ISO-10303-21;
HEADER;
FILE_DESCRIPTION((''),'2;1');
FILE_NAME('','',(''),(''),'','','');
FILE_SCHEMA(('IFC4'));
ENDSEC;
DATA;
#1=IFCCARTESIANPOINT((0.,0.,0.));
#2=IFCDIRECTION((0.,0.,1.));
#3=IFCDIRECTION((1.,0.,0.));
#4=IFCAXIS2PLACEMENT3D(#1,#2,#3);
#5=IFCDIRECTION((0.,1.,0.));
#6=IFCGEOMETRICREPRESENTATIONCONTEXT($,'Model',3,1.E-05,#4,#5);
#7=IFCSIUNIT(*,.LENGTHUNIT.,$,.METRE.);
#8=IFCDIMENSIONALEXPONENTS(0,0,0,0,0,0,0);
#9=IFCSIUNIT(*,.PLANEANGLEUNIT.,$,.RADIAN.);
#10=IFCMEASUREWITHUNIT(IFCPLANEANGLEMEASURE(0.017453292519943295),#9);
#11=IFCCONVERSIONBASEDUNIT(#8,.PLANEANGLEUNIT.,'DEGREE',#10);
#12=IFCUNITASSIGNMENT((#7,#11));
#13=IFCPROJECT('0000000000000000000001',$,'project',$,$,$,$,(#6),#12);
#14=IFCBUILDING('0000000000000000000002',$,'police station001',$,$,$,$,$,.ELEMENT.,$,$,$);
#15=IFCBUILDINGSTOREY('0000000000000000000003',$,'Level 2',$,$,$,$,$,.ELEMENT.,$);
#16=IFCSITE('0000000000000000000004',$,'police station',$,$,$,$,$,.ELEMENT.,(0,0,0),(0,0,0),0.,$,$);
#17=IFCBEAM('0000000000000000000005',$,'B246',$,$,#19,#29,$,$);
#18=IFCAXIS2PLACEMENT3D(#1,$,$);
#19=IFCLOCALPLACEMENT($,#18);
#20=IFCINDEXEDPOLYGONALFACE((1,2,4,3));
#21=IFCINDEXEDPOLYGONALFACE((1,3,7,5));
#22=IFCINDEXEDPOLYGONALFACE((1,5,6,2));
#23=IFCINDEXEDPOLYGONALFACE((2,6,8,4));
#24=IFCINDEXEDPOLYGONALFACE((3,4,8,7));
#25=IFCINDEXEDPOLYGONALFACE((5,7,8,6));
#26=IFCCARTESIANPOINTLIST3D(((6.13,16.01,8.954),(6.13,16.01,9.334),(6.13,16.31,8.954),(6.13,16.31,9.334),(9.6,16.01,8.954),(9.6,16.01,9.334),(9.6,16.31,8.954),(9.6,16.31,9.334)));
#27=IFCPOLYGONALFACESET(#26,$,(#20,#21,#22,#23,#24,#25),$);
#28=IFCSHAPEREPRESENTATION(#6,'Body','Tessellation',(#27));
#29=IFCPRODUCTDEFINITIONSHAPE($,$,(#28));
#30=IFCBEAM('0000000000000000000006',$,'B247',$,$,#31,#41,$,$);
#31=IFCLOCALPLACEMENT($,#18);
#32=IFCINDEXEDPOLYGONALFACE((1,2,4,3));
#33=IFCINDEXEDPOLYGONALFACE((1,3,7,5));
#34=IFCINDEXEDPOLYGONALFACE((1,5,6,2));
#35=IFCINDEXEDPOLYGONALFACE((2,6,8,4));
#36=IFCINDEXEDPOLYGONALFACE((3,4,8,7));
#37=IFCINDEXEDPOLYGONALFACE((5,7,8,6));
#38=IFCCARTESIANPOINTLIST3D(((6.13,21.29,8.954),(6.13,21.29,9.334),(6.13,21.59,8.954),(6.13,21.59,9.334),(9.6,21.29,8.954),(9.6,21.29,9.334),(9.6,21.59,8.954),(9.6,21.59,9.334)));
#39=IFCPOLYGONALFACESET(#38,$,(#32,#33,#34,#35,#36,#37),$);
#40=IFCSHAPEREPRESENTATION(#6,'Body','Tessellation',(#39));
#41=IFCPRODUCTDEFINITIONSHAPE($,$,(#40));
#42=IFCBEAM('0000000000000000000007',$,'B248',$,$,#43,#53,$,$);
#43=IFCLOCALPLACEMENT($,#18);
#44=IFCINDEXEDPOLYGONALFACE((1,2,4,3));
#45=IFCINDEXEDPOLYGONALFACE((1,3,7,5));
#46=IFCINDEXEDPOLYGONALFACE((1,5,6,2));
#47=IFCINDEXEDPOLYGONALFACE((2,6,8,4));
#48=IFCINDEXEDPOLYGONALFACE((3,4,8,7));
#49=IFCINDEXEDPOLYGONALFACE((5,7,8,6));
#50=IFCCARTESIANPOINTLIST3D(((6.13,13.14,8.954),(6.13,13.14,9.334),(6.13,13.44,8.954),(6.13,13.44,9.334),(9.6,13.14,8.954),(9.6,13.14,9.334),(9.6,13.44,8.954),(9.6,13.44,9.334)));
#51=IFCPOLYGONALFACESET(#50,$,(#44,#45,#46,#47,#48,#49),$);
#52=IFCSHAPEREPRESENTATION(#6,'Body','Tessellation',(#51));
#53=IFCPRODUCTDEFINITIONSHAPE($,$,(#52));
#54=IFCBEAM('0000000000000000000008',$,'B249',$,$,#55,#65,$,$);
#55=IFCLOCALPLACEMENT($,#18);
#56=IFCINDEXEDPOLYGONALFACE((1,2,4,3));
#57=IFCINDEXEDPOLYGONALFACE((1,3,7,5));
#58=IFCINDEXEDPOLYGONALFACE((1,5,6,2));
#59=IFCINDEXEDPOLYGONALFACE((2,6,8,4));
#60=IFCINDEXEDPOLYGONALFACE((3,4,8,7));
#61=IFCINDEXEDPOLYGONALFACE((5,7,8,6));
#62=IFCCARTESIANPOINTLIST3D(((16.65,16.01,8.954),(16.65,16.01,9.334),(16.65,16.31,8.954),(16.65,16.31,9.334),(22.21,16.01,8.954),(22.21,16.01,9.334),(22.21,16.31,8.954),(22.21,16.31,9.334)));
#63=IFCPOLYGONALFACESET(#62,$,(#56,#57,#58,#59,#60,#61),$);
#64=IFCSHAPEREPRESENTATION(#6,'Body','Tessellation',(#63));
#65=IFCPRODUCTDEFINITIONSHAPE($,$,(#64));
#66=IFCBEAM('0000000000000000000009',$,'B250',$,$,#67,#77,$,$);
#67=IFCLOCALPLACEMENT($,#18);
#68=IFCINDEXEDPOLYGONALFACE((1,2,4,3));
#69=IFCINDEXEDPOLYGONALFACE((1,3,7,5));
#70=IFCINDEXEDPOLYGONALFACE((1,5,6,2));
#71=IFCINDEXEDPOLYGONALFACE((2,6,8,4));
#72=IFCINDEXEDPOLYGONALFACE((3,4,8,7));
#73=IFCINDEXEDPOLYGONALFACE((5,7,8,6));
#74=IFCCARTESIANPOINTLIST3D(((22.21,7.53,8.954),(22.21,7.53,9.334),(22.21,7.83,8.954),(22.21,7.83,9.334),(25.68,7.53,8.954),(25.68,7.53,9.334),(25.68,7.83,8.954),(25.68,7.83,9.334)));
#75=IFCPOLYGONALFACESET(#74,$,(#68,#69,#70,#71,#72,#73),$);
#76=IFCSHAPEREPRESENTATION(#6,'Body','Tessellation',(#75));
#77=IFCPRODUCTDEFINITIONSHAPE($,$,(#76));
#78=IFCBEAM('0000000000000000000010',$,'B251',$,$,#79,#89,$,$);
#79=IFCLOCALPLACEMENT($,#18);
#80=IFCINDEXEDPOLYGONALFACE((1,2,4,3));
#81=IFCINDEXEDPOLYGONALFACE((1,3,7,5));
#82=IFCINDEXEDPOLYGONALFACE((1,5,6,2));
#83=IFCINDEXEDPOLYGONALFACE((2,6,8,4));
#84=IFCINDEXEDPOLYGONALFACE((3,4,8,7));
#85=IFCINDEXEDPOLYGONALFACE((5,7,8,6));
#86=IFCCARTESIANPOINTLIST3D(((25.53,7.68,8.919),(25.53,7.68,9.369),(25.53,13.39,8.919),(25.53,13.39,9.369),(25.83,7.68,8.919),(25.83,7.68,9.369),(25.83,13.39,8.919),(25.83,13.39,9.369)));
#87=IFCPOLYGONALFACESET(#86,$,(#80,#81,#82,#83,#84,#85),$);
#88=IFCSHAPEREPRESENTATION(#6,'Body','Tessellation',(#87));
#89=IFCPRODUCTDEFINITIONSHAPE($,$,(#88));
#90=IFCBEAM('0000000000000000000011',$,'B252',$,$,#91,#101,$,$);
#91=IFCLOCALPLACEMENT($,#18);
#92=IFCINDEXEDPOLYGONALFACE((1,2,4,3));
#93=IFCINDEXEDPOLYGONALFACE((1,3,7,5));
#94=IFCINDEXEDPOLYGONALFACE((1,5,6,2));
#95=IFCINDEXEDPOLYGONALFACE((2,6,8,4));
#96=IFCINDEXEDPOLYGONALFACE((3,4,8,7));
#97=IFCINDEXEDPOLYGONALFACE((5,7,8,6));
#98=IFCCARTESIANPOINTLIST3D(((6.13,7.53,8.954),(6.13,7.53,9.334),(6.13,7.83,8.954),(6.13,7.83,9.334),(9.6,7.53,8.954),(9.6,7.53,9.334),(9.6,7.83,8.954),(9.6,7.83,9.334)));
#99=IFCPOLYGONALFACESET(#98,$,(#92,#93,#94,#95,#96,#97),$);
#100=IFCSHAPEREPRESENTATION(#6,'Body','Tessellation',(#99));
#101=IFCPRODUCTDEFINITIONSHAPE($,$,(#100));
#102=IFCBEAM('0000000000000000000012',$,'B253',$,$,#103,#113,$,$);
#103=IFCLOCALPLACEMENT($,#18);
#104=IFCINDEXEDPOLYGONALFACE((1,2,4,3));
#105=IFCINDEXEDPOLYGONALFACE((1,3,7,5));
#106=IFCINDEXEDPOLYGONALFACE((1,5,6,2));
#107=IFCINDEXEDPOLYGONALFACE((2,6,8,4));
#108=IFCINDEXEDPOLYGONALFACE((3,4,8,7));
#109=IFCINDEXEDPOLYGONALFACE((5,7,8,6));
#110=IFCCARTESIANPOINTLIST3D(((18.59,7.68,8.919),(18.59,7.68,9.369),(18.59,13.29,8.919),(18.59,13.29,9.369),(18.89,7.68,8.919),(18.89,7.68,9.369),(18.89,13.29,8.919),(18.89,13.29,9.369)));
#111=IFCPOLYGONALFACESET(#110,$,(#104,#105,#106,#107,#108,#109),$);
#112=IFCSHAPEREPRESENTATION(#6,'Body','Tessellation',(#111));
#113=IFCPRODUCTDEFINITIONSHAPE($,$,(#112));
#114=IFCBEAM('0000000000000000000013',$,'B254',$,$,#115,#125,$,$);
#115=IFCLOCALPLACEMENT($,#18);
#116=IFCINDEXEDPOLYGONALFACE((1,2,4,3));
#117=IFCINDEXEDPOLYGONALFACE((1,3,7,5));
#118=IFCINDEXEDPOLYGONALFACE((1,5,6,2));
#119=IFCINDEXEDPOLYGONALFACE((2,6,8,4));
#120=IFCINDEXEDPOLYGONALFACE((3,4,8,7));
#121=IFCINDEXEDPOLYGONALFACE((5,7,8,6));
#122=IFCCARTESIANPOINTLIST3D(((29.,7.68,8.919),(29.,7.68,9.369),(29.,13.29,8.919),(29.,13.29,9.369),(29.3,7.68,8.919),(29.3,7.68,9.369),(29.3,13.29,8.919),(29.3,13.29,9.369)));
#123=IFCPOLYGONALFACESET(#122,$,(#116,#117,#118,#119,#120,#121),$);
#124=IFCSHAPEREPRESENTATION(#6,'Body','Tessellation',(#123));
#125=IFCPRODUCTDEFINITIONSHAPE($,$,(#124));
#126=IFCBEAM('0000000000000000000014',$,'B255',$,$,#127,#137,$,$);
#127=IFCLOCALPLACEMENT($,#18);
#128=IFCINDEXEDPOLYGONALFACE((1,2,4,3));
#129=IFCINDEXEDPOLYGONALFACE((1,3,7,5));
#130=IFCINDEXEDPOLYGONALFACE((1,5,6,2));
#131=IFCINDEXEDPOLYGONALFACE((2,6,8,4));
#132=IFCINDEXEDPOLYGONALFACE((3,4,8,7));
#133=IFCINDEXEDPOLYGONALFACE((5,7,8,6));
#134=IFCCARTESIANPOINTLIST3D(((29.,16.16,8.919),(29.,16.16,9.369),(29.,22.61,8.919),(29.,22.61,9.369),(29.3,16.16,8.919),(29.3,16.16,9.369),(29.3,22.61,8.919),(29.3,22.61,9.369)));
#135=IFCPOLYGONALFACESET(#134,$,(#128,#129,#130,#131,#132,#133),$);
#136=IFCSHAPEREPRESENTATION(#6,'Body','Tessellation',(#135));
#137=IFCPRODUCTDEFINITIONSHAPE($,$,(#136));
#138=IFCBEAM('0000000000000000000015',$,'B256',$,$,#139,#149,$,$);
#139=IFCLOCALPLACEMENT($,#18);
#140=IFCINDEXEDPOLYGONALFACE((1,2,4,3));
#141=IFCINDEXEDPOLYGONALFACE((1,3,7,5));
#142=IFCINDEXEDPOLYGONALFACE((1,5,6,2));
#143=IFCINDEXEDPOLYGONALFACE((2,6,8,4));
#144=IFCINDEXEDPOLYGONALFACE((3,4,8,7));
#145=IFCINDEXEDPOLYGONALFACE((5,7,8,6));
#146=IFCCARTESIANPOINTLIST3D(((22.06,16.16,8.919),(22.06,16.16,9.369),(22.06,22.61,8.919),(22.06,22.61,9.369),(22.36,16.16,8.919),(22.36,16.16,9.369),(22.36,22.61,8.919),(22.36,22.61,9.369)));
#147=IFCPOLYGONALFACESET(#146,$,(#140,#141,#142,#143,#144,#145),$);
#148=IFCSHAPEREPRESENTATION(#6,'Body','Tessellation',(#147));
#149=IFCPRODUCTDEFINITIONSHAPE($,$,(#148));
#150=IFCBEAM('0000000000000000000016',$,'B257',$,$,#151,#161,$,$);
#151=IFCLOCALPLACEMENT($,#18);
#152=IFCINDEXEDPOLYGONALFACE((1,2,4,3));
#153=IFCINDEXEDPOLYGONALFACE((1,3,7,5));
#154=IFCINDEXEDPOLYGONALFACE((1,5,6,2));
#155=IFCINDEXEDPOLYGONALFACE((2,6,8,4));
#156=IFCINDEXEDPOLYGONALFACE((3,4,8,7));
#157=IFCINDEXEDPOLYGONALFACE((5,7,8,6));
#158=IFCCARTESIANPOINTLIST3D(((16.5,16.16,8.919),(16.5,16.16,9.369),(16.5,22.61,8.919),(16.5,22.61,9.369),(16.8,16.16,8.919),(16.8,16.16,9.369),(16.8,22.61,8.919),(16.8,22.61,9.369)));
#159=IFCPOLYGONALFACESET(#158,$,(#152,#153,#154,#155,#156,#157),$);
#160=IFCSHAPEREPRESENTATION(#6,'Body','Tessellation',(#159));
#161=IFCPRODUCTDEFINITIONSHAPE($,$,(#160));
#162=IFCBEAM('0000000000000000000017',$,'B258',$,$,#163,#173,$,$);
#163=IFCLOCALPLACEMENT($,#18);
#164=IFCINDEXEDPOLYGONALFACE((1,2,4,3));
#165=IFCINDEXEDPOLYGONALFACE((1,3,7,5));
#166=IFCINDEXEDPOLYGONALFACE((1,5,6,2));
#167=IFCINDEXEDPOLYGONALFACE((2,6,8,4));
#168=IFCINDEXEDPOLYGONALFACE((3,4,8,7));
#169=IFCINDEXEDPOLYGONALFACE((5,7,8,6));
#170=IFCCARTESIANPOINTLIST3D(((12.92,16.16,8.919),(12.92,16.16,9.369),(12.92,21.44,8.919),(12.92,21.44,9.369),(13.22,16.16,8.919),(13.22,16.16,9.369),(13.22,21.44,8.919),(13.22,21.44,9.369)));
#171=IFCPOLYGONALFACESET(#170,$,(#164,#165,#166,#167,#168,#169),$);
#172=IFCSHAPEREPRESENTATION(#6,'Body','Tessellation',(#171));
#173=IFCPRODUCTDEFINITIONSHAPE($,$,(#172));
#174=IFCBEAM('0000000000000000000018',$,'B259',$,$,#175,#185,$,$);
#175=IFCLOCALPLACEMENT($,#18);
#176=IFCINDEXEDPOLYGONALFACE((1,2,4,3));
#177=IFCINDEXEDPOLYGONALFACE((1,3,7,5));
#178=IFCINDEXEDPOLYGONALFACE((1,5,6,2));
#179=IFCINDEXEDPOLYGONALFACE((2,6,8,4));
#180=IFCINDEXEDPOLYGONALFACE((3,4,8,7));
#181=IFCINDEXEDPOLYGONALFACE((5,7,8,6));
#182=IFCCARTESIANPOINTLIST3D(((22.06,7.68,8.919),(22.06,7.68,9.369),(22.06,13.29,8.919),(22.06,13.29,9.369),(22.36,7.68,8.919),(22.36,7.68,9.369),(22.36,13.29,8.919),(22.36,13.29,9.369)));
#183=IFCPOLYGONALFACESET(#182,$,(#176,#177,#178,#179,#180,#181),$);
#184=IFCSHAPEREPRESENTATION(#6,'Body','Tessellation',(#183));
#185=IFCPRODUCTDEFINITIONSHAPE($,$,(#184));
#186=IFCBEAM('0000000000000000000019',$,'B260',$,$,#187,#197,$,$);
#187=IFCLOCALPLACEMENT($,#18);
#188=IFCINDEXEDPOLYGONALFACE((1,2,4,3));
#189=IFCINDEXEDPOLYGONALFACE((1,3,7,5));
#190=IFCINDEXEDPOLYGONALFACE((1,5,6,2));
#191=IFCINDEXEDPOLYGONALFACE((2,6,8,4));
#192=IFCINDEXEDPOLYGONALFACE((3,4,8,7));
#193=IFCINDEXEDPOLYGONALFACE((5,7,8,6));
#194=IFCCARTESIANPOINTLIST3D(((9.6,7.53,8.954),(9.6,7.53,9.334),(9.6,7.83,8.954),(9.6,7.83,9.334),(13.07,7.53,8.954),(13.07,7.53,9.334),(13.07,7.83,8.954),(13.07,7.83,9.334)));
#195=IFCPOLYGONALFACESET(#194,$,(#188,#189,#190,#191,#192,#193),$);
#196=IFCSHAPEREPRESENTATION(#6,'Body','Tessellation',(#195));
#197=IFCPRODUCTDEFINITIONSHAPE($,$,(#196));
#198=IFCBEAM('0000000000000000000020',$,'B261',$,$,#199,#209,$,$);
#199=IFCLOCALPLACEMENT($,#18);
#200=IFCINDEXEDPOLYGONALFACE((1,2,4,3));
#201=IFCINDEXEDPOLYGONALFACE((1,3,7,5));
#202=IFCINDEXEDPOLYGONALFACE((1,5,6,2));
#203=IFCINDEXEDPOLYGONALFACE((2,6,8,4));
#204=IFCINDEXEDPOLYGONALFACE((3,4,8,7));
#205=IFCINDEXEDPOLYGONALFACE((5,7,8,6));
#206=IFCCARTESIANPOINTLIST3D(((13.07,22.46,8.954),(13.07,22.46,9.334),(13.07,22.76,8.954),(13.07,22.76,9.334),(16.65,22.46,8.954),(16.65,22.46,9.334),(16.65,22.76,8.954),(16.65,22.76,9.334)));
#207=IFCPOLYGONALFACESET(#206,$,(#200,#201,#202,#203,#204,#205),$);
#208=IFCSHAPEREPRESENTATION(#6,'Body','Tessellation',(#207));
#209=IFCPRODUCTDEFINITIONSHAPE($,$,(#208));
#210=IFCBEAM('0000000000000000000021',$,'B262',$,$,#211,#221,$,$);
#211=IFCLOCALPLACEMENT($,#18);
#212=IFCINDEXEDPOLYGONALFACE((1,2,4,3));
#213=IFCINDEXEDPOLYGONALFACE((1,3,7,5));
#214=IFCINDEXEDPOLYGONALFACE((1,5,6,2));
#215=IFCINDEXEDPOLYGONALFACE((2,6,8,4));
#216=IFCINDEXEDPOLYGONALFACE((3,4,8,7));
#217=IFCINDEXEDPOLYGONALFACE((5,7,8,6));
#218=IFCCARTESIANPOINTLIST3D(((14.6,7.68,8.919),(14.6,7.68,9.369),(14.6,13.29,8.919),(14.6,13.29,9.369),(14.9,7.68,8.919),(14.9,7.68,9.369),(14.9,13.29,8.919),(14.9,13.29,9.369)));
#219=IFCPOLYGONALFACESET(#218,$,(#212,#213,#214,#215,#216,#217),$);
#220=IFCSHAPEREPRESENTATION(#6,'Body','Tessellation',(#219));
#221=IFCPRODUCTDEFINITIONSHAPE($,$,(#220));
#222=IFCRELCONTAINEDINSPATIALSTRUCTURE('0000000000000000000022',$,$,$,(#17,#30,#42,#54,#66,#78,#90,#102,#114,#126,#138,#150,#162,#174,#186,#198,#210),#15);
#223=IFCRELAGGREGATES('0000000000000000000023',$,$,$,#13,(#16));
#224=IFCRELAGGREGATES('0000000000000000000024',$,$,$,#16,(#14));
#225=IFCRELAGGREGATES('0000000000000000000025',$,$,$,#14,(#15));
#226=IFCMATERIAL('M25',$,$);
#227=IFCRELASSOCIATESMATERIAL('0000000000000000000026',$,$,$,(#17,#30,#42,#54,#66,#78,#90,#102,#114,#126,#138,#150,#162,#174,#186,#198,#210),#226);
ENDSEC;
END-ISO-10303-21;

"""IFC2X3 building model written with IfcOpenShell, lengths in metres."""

from ifc_helpers import new_model, entity, si_unit, converted_unit, direction, frame, frame_2d, origin_with_axes, place, context, project, spatial, rectangle, extrude, material, element, save


model = new_model("IFC2X3")

# Units and contexts
model_context = context("Model", 3, precision=1e-05, world=origin_with_axes(), true_north=direction((0.0, 1.0, 0.0)))
ifc_project = project(units=[si_unit("LENGTHUNIT", "METRE"), converted_unit("PLANEANGLEUNIT", "DEGREE", entity("IfcPlaneAngleMeasure", 0.017453292519943295), si_unit("PLANEANGLEUNIT", "RADIAN"), dimensions=[0, 0, 0, 0, 0, 0, 0])], contexts=[model_context])

# Site, building, storey
site = spatial("IfcSite", under=ifc_project, Name="police station", CompositionType="ELEMENT", RefLatitude=(0, 0, 0), RefLongitude=(0, 0, 0), RefElevation=0.0)
building = spatial("IfcBuilding", under=site, Name="police station001", CompositionType="ELEMENT")
storey = spatial("IfcBuildingStorey", under=building, Name="Level 2", CompositionType="ELEMENT")

# Beams
ifc_material = material(Name="M25")
placement = place(None, origin_with_axes())
element("IfcBeam", 1, at=placement, inside=storey, material=ifc_material, Name="B246", context=model_context, shape_type="SweptSolid", body=[
    extrude(rectangle(XDim=0.3, YDim=0.38, at=frame_2d((0.0, 0.0), x_axis=(0.0, 1.0, 0.0))), frame((9.6, 16.16, 9.144), z_axis=(-1.0, 0.0, 0.0), x_axis=(0.0, 0.0, -1.0)), (0.0, 0.0, 1.0), 3.47),
])
element("IfcBeam", 2, at=placement, inside=storey, material=ifc_material, Name="B247", context=model_context, shape_type="SweptSolid", body=[
    extrude(rectangle(XDim=0.3, YDim=0.38, at=frame_2d((0.0, 0.0), x_axis=(0.0, 1.0, 0.0))), frame((9.6, 21.44, 9.144), z_axis=(-1.0, 0.0, 0.0), x_axis=(0.0, 0.0, -1.0)), (0.0, 0.0, 1.0), 3.47),
])
element("IfcBeam", 3, at=placement, inside=storey, material=ifc_material, Name="B248", context=model_context, shape_type="SweptSolid", body=[
    extrude(rectangle(XDim=0.3, YDim=0.38, at=frame_2d((0.0, 0.0), x_axis=(0.0, 1.0, 0.0))), frame((9.6, 13.29, 9.144), z_axis=(-1.0, 0.0, 0.0), x_axis=(0.0, 0.0, -1.0)), (0.0, 0.0, 1.0), 3.47),
])
element("IfcBeam", 4, at=placement, inside=storey, material=ifc_material, Name="B249", context=model_context, shape_type="SweptSolid", body=[
    extrude(rectangle(XDim=0.3, YDim=0.38, at=frame_2d((0.0, 0.0), x_axis=(0.0, 1.0, 0.0))), frame((22.21, 16.16, 9.144), z_axis=(-1.0, 0.0, 0.0), x_axis=(0.0, 0.0, -1.0)), (0.0, 0.0, 1.0), 5.56),
])
element("IfcBeam", 5, at=placement, inside=storey, material=ifc_material, Name="B250", context=model_context, shape_type="SweptSolid", body=[
    extrude(rectangle(XDim=0.3, YDim=0.38, at=frame_2d((0.0, 0.0), x_axis=(0.0, 1.0, 0.0))), frame((25.68, 7.68, 9.144), z_axis=(-1.0, 0.0, 0.0), x_axis=(0.0, 0.0, -1.0)), (0.0, 0.0, 1.0), 3.47),
])
element("IfcBeam", 6, at=placement, inside=storey, material=ifc_material, Name="B251", context=model_context, shape_type="SweptSolid", body=[
    extrude(rectangle(XDim=0.3, YDim=0.45, at=frame_2d((0.0, 0.0), x_axis=(0.0, 1.0, 0.0))), frame((25.68, 7.68, 9.144), z_axis=(0.0, 1.0, 0.0), x_axis=(0.0, 0.0, -1.0)), (0.0, 0.0, 1.0), 5.71),
])
element("IfcBeam", 7, at=placement, inside=storey, material=ifc_material, Name="B252", context=model_context, shape_type="SweptSolid", body=[
    extrude(rectangle(XDim=0.3, YDim=0.38, at=frame_2d((0.0, 0.0), x_axis=(0.0, 1.0, 0.0))), frame((6.13, 7.68, 9.144), z_axis=(1.0, 0.0, 0.0), x_axis=(0.0, 0.0, -1.0)), (0.0, 0.0, 1.0), 3.47),
])
element("IfcBeam", 8, at=placement, inside=storey, material=ifc_material, Name="B253", context=model_context, shape_type="SweptSolid", body=[
    extrude(rectangle(XDim=0.3, YDim=0.45, at=frame_2d((0.0, 0.0), x_axis=(0.0, 1.0, 0.0))), frame((18.74, 13.29, 9.144), z_axis=(0.0, -1.0, 0.0), x_axis=(0.0, 0.0, -1.0)), (0.0, 0.0, 1.0), 5.61),
])
element("IfcBeam", 9, at=placement, inside=storey, material=ifc_material, Name="B254", context=model_context, shape_type="SweptSolid", body=[
    extrude(rectangle(XDim=0.3, YDim=0.45, at=frame_2d((0.0, 0.0), x_axis=(0.0, 1.0, 0.0))), frame((29.15, 13.29, 9.144), z_axis=(0.0, -1.0, 0.0), x_axis=(0.0, 0.0, -1.0)), (0.0, 0.0, 1.0), 5.61),
])
element("IfcBeam", 10, at=placement, inside=storey, material=ifc_material, Name="B255", context=model_context, shape_type="SweptSolid", body=[
    extrude(rectangle(XDim=0.3, YDim=0.45, at=frame_2d((0.0, 0.0), x_axis=(0.0, 1.0, 0.0))), frame((29.15, 16.16, 9.144), z_axis=(0.0, 1.0, 0.0), x_axis=(0.0, 0.0, -1.0)), (0.0, 0.0, 1.0), 6.45),
])
element("IfcBeam", 11, at=placement, inside=storey, material=ifc_material, Name="B256", context=model_context, shape_type="SweptSolid", body=[
    extrude(rectangle(XDim=0.3, YDim=0.45, at=frame_2d((0.0, 0.0), x_axis=(0.0, 1.0, 0.0))), frame((22.21, 16.16, 9.144), z_axis=(0.0, 1.0, 0.0), x_axis=(0.0, 0.0, -1.0)), (0.0, 0.0, 1.0), 6.45),
])
element("IfcBeam", 12, at=placement, inside=storey, material=ifc_material, Name="B257", context=model_context, shape_type="SweptSolid", body=[
    extrude(rectangle(XDim=0.3, YDim=0.45, at=frame_2d((0.0, 0.0), x_axis=(0.0, 1.0, 0.0))), frame((16.65, 16.16, 9.144), z_axis=(0.0, 1.0, 0.0), x_axis=(0.0, 0.0, -1.0)), (0.0, 0.0, 1.0), 6.45),
])
element("IfcBeam", 13, at=placement, inside=storey, material=ifc_material, Name="B258", context=model_context, shape_type="SweptSolid", body=[
    extrude(rectangle(XDim=0.3, YDim=0.45, at=frame_2d((0.0, 0.0), x_axis=(0.0, 1.0, 0.0))), frame((13.07, 16.16, 9.144), z_axis=(0.0, 1.0, 0.0), x_axis=(0.0, 0.0, -1.0)), (0.0, 0.0, 1.0), 5.28),
])
element("IfcBeam", 14, at=placement, inside=storey, material=ifc_material, Name="B259", context=model_context, shape_type="SweptSolid", body=[
    extrude(rectangle(XDim=0.3, YDim=0.45, at=frame_2d((0.0, 0.0), x_axis=(0.0, 1.0, 0.0))), frame((22.21, 7.68, 9.144), z_axis=(0.0, 1.0, 0.0), x_axis=(0.0, 0.0, -1.0)), (0.0, 0.0, 1.0), 5.61),
])
element("IfcBeam", 15, at=placement, inside=storey, material=ifc_material, Name="B260", context=model_context, shape_type="SweptSolid", body=[
    extrude(rectangle(XDim=0.3, YDim=0.38, at=frame_2d((0.0, 0.0), x_axis=(0.0, 1.0, 0.0))), frame((9.6, 7.68, 9.144), z_axis=(1.0, 0.0, 0.0), x_axis=(0.0, 0.0, -1.0)), (0.0, 0.0, 1.0), 3.47),
])
element("IfcBeam", 16, at=placement, inside=storey, material=ifc_material, Name="B261", context=model_context, shape_type="SweptSolid", body=[
    extrude(rectangle(XDim=0.3, YDim=0.38, at=frame_2d((0.0, 0.0), x_axis=(0.0, 1.0, 0.0))), frame((13.07, 22.61, 9.144), z_axis=(1.0, 0.0, 0.0), x_axis=(0.0, 0.0, -1.0)), (0.0, 0.0, 1.0), 3.58),
])
element("IfcBeam", 17, at=placement, inside=storey, material=ifc_material, Name="B262", context=model_context, shape_type="SweptSolid", body=[
    extrude(rectangle(XDim=0.3, YDim=0.45, at=frame_2d((0.0, 0.0), x_axis=(0.0, 1.0, 0.0))), frame((14.75, 7.68, 9.144), z_axis=(0.0, 1.0, 0.0), x_axis=(0.0, 0.0, -1.0)), (0.0, 0.0, 1.0), 5.61),
])

save(model, "model.ifc")
